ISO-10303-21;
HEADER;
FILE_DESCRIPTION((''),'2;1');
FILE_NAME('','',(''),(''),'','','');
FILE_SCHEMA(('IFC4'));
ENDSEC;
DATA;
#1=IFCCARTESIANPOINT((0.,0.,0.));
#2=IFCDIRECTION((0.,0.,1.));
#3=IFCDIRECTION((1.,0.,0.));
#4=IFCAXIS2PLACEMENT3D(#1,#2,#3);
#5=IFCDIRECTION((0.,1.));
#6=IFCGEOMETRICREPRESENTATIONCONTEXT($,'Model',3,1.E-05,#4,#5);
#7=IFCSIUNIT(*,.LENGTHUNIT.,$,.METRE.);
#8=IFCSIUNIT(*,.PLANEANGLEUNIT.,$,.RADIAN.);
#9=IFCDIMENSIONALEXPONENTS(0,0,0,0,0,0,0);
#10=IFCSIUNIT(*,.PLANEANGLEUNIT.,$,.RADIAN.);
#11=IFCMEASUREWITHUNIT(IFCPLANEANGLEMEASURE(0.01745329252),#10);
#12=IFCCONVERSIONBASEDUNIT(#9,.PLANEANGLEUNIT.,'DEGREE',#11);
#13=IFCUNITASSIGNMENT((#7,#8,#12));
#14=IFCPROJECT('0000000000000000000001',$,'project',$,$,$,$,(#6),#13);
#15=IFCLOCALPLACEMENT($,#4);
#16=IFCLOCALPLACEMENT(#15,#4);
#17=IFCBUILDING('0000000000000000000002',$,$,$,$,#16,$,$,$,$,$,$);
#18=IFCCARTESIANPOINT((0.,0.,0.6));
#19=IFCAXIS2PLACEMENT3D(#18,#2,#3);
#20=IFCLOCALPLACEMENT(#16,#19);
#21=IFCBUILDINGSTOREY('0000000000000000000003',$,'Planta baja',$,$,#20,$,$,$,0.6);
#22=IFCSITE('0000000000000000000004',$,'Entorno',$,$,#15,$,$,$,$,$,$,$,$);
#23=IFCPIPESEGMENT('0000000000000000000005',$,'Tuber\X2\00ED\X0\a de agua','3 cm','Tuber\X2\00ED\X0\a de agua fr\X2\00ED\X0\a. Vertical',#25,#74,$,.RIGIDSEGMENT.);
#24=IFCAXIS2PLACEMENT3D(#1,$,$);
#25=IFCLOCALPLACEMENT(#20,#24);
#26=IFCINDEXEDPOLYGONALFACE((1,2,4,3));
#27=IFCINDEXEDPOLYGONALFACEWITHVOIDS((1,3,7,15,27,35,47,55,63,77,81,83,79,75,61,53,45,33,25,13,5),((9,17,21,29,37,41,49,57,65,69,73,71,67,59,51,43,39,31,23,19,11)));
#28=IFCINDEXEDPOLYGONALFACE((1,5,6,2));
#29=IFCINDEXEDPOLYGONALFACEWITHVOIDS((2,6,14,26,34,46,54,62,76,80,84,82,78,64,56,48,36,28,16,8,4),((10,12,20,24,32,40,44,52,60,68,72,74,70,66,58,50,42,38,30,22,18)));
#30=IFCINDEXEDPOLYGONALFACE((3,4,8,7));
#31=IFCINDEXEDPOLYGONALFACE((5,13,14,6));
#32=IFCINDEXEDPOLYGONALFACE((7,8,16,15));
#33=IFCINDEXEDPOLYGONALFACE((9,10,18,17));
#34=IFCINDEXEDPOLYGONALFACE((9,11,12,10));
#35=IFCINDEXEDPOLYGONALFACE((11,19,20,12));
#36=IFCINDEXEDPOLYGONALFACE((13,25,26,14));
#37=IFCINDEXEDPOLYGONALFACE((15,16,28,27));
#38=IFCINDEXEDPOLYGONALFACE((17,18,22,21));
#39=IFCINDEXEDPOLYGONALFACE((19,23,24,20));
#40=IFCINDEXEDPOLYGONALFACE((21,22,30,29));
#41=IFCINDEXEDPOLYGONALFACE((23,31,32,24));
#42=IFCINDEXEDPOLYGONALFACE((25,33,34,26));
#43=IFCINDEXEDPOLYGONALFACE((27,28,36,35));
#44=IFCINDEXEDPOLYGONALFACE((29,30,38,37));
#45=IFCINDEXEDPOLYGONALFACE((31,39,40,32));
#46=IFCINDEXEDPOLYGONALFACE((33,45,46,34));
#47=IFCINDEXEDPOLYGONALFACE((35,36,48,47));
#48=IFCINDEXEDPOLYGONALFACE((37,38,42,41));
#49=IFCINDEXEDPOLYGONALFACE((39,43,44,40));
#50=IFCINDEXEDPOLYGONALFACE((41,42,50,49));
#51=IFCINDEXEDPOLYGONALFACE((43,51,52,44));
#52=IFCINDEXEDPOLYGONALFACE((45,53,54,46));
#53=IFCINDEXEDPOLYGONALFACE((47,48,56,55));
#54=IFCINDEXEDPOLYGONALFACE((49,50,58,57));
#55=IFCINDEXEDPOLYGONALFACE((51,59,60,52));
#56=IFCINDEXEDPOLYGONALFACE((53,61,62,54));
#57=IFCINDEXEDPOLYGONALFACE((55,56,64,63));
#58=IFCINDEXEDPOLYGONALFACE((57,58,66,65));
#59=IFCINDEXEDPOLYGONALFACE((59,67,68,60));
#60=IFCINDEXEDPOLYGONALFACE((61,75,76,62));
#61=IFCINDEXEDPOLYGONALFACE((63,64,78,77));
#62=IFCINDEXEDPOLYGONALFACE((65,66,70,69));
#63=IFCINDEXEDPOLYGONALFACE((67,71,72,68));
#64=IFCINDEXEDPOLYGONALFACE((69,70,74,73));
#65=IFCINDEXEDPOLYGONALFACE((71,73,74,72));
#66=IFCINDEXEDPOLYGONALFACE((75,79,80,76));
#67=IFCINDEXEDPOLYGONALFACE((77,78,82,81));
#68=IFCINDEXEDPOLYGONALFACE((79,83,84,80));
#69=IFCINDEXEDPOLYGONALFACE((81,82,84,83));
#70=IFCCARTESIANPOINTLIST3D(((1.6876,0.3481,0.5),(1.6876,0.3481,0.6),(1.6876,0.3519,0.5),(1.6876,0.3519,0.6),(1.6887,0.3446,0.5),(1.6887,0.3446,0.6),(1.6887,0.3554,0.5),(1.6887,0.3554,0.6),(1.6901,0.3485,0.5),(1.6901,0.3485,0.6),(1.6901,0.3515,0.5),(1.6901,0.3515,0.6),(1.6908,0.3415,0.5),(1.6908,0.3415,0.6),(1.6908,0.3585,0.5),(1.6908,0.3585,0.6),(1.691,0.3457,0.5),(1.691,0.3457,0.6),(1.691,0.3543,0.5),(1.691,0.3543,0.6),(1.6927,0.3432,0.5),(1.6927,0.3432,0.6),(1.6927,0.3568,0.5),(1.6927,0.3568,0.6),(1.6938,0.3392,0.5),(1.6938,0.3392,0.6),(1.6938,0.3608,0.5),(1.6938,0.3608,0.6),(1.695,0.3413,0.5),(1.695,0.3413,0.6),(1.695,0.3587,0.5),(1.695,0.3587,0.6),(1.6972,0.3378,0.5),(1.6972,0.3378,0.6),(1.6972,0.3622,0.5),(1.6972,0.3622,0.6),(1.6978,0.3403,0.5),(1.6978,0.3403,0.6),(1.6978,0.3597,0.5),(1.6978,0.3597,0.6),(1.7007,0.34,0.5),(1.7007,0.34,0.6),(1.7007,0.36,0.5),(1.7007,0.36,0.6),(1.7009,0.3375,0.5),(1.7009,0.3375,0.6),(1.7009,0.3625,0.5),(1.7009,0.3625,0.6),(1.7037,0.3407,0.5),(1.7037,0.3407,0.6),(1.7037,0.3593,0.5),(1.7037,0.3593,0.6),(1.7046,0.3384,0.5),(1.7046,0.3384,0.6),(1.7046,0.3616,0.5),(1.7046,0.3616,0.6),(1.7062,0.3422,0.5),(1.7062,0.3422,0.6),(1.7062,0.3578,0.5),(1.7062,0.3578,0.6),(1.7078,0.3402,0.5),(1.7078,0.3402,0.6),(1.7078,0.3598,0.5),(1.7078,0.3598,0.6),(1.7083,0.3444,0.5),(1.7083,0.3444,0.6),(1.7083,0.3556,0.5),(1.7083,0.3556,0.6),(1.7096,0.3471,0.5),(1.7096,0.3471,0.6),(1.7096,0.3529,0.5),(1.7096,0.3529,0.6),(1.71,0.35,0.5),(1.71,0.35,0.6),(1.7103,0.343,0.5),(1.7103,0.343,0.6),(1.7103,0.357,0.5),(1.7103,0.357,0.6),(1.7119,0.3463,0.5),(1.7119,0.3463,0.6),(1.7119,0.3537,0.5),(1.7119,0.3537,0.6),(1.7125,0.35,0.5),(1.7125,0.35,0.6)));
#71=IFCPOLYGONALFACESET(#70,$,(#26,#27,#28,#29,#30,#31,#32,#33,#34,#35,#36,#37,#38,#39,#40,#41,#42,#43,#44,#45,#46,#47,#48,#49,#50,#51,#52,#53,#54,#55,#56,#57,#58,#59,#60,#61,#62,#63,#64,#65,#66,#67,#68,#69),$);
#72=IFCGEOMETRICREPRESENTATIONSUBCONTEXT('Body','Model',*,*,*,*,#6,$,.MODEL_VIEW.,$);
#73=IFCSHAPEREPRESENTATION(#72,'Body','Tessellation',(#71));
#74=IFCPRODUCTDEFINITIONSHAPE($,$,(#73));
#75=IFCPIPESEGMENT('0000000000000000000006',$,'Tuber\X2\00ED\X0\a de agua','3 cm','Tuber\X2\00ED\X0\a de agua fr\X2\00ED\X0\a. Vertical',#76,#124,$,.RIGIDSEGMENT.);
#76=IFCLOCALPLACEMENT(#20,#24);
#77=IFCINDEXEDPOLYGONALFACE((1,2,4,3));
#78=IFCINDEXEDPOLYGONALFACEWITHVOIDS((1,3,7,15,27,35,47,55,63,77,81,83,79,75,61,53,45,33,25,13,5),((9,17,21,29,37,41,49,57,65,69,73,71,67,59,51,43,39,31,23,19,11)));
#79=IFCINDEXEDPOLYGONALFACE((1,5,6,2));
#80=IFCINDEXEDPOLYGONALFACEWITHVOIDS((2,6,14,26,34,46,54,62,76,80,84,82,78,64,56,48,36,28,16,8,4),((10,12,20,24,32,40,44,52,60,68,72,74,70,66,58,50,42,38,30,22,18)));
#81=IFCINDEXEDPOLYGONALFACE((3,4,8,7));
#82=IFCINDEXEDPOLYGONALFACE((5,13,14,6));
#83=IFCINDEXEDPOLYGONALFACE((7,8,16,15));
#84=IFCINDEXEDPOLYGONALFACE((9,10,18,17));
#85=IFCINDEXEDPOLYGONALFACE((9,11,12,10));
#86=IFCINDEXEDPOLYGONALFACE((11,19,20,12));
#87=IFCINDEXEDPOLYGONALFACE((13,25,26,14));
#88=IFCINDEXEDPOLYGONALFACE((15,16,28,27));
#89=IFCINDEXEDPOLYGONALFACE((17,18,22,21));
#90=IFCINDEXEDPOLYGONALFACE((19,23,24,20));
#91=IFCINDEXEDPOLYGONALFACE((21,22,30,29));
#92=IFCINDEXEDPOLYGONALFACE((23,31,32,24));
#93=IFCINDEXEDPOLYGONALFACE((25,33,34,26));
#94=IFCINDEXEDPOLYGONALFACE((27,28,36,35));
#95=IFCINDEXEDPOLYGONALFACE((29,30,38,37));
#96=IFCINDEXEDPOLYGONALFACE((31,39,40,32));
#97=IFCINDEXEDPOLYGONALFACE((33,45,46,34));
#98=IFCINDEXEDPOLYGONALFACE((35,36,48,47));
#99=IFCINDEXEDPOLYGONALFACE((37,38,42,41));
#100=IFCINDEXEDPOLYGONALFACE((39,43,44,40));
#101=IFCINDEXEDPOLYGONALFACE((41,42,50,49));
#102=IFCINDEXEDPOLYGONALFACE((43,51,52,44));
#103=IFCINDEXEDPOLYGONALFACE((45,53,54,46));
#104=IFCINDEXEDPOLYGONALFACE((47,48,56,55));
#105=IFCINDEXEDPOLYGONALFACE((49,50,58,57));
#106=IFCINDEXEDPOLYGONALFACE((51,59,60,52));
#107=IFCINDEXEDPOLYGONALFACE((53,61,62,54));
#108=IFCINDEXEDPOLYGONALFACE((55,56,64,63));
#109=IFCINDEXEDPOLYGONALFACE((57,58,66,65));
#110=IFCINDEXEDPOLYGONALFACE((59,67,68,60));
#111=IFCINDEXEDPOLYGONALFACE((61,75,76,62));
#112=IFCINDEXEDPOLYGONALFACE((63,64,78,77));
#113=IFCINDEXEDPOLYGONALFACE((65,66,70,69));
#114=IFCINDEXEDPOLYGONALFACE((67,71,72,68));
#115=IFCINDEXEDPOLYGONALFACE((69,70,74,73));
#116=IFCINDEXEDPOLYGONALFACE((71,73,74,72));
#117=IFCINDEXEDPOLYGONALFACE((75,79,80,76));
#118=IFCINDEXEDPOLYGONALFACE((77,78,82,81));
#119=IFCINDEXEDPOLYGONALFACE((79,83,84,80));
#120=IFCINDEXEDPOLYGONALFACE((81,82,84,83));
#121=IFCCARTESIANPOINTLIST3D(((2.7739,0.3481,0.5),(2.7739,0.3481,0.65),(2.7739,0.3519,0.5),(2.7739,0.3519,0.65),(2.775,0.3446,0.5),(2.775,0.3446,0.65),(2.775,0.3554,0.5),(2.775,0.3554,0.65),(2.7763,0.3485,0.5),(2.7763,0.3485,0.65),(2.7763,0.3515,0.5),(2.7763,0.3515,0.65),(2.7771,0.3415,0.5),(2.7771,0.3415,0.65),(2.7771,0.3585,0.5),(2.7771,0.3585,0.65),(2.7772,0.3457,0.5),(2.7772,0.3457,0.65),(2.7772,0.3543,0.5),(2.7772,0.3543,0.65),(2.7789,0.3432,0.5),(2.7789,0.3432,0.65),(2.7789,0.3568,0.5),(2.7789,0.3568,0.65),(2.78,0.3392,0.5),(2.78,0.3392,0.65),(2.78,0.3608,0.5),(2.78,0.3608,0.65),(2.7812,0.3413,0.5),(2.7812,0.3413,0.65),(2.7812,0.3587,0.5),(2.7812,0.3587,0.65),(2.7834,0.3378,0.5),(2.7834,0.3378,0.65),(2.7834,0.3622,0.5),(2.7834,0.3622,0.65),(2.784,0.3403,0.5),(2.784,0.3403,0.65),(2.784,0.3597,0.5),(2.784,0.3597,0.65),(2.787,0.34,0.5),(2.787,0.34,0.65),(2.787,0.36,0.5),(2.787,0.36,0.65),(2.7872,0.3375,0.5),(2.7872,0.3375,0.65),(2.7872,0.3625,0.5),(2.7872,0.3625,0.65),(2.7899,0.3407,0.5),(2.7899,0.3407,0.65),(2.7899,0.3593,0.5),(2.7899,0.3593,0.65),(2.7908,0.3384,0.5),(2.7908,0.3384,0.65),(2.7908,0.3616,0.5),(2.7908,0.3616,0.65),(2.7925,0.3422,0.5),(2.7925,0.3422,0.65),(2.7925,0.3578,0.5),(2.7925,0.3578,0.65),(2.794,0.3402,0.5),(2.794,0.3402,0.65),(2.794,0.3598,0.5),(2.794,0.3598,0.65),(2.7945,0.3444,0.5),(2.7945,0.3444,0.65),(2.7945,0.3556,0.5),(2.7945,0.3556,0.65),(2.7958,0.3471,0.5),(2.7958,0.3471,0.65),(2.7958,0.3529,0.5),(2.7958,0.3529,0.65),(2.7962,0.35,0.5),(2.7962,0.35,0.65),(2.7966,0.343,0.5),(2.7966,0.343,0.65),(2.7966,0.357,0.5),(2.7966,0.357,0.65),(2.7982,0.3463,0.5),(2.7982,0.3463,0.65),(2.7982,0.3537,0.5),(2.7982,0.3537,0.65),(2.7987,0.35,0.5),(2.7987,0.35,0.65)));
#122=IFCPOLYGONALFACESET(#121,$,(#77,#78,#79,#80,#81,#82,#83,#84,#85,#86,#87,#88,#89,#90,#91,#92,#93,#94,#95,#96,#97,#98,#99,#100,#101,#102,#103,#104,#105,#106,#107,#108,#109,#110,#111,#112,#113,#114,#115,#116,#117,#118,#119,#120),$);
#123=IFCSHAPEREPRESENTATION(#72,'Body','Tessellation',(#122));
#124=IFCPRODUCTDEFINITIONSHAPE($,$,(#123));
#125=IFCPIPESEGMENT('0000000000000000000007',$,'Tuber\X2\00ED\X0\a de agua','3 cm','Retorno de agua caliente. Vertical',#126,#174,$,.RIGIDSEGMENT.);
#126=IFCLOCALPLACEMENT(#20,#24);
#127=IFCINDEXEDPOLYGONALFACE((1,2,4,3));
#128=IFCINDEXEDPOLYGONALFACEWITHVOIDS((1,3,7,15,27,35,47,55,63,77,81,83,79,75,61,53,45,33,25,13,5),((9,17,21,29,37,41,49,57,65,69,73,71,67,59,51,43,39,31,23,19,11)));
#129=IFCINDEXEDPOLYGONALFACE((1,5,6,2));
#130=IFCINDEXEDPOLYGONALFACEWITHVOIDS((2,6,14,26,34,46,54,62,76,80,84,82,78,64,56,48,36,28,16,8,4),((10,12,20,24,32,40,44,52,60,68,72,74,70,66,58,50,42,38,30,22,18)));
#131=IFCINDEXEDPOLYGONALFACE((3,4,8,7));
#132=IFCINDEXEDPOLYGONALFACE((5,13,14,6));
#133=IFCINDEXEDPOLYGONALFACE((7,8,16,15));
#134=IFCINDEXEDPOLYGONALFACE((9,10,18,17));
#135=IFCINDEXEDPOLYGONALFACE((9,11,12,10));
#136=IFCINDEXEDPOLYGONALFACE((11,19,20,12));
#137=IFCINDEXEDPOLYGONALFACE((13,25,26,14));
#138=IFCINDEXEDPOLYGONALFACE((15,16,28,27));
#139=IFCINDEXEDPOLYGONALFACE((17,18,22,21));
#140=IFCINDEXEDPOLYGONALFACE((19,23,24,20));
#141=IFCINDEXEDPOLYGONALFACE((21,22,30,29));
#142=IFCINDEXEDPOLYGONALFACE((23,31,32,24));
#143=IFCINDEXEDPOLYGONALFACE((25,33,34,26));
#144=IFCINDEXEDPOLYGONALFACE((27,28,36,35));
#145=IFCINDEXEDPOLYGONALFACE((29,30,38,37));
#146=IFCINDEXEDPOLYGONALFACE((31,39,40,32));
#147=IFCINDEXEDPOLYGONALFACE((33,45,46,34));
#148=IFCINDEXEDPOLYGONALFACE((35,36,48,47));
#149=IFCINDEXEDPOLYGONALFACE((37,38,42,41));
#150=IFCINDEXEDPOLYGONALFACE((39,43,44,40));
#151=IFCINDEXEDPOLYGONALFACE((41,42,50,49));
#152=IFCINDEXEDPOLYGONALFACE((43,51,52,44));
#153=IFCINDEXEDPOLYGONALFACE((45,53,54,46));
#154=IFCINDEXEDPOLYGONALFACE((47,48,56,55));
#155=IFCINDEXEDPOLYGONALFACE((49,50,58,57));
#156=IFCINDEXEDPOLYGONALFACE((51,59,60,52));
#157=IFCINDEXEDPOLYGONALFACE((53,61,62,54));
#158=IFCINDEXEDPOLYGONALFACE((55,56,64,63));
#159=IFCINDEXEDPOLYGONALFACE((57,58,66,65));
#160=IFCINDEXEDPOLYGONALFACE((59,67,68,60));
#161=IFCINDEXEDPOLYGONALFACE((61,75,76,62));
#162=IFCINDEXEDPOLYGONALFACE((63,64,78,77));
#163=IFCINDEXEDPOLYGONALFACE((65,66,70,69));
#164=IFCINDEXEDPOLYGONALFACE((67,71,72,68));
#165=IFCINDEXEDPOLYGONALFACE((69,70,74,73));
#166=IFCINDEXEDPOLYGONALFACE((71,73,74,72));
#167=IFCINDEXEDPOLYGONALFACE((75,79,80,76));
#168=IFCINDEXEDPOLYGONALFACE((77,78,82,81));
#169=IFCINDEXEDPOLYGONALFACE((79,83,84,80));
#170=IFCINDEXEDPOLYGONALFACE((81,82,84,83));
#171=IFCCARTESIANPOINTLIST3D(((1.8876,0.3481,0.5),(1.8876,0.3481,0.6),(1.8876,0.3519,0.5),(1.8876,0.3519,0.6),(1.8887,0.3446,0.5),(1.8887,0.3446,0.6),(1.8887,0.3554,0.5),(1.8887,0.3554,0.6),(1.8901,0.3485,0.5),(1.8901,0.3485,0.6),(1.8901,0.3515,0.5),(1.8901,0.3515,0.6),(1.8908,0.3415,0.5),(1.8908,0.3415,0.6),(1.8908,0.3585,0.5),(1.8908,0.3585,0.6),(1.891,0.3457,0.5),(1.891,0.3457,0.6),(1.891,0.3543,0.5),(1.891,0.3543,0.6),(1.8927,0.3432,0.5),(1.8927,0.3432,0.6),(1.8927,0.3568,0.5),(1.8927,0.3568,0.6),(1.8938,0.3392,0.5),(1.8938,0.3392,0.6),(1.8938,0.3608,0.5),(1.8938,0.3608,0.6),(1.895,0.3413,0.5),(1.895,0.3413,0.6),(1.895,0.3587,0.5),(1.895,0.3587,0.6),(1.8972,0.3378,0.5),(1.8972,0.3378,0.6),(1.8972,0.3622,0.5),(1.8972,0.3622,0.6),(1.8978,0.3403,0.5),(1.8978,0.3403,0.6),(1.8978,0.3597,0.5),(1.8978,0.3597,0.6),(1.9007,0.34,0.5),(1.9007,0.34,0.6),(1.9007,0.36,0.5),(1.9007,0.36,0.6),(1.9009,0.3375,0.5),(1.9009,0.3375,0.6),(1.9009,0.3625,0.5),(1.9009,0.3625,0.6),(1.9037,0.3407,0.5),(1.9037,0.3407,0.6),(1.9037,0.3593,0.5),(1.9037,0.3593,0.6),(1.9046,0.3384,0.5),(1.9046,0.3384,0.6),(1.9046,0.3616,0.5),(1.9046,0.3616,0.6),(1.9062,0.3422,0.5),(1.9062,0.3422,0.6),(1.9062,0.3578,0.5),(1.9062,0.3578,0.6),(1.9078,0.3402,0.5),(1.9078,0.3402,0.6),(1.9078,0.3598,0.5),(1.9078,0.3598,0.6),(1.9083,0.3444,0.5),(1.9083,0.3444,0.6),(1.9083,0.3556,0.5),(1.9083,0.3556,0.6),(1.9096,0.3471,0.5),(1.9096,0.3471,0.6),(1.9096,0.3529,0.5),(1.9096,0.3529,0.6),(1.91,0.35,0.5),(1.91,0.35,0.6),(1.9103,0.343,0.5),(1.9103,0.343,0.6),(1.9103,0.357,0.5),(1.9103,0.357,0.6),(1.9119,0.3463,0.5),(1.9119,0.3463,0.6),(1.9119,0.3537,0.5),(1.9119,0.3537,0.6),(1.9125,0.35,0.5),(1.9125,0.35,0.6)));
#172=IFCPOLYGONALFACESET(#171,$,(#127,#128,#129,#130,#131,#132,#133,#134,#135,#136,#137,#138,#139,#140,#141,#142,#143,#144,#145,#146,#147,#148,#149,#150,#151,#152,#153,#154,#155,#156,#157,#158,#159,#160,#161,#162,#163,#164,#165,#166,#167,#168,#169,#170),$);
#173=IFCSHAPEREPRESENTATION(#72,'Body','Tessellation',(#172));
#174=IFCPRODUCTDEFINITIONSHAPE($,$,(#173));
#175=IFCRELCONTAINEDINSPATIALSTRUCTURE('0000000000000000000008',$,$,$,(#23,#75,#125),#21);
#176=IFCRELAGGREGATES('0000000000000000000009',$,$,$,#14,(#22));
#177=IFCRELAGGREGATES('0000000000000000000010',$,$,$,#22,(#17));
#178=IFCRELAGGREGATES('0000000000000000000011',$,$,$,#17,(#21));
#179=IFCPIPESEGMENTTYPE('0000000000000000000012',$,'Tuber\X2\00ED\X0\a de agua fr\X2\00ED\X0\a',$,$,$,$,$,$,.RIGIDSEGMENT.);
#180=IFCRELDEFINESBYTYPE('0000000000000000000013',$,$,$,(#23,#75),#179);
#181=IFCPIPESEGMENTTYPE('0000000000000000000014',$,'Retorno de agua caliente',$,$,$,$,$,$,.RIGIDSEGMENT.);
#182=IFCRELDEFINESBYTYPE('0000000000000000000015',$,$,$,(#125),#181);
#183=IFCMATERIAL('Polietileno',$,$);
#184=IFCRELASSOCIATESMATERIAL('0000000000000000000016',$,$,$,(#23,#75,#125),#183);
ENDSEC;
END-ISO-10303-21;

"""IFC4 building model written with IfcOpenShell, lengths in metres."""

from ifc_helpers import new_model, entity, si_unit, converted_unit, direction, frame, origin_with_axes, origin_2d_with_axis, place, context, subcontext, project, spatial, hollow_circle, extrude, material, type_object, element, save


model = new_model("IFC4")

# Units and contexts
model_context = context("Model", 3, precision=1e-05, world=origin_with_axes(), true_north=direction((0.0, 1.0)))
body_context = subcontext(model_context, "Body", "Model", "MODEL_VIEW")
ifc_project = project(units=[si_unit("LENGTHUNIT", "METRE"), si_unit("PLANEANGLEUNIT", "RADIAN"), converted_unit("PLANEANGLEUNIT", "DEGREE", entity("IfcPlaneAngleMeasure", 0.01745329252), si_unit("PLANEANGLEUNIT", "RADIAN"), dimensions=[0, 0, 0, 0, 0, 0, 0])], contexts=[model_context])

# Site, building, storey
site_placement = place(None, origin_with_axes())
site = spatial("IfcSite", under=ifc_project, at=site_placement, Name="Entorno")
building_placement = place(site_placement, origin_with_axes())
building = spatial("IfcBuilding", under=site, at=building_placement)
storey_placement = place(building_placement, frame((0.0, 0.0, 0.6), z_axis=(0.0, 0.0, 1.0), x_axis=(1.0, 0.0, 0.0)))
storey = spatial("IfcBuildingStorey", under=building, at=storey_placement, Name="Planta baja", Elevation=0.6)

# Pipe segments
ifc_material_1 = material(Name="Polietileno")
pipe_segment_type_1 = type_object("IfcPipeSegmentType", Name="Tubería de agua fría", PredefinedType="RIGIDSEGMENT")
pipe_segment_1_placement = place(storey_placement, frame((1.7, 0.35, 0.5), z_axis=(0.0, 0.0, 1.0), x_axis=(1.0, 0.0, 0.0)))
element("IfcPipeSegment", 1, at=pipe_segment_1_placement, inside=storey, type_object=pipe_segment_type_1, material=ifc_material_1, Name="Tubería de agua", Description="3 cm", ObjectType="Tubería de agua fría. Vertical", PredefinedType="RIGIDSEGMENT", context=body_context, shape_type="SweptSolid", body=[
    extrude(hollow_circle(Radius=0.0125, WallThickness=0.0025, at=origin_2d_with_axis()), origin_with_axes(), (0.0, 0.0, 1.0), 0.1),
])
pipe_segment_2_placement = place(storey_placement, frame((2.7862, 0.35, 0.5), z_axis=(0.0, 0.0, 1.0), x_axis=(1.0, 0.0, 0.0)))
element("IfcPipeSegment", 2, at=pipe_segment_2_placement, inside=storey, type_object=pipe_segment_type_1, material=ifc_material_1, Name="Tubería de agua", Description="3 cm", ObjectType="Tubería de agua fría. Vertical", PredefinedType="RIGIDSEGMENT", context=body_context, shape_type="SweptSolid", body=[
    extrude(hollow_circle(Radius=0.0125, WallThickness=0.0025, at=origin_2d_with_axis()), origin_with_axes(), (0.0, 0.0, 1.0), 0.15),
])
pipe_segment_type_2 = type_object("IfcPipeSegmentType", Name="Retorno de agua caliente", PredefinedType="RIGIDSEGMENT")
pipe_segment_3_placement = place(storey_placement, frame((1.9, 0.35, 0.5), z_axis=(0.0, 0.0, 1.0), x_axis=(1.0, 0.0, 0.0)))
element("IfcPipeSegment", 3, at=pipe_segment_3_placement, inside=storey, type_object=pipe_segment_type_2, material=ifc_material_1, Name="Tubería de agua", Description="3 cm", ObjectType="Retorno de agua caliente. Vertical", PredefinedType="RIGIDSEGMENT", context=body_context, shape_type="SweptSolid", body=[
    extrude(hollow_circle(Radius=0.0125, WallThickness=0.0025, at=origin_2d_with_axis()), origin_with_axes(), (0.0, 0.0, 1.0), 0.1),
])

save(model, "model.ifc")
